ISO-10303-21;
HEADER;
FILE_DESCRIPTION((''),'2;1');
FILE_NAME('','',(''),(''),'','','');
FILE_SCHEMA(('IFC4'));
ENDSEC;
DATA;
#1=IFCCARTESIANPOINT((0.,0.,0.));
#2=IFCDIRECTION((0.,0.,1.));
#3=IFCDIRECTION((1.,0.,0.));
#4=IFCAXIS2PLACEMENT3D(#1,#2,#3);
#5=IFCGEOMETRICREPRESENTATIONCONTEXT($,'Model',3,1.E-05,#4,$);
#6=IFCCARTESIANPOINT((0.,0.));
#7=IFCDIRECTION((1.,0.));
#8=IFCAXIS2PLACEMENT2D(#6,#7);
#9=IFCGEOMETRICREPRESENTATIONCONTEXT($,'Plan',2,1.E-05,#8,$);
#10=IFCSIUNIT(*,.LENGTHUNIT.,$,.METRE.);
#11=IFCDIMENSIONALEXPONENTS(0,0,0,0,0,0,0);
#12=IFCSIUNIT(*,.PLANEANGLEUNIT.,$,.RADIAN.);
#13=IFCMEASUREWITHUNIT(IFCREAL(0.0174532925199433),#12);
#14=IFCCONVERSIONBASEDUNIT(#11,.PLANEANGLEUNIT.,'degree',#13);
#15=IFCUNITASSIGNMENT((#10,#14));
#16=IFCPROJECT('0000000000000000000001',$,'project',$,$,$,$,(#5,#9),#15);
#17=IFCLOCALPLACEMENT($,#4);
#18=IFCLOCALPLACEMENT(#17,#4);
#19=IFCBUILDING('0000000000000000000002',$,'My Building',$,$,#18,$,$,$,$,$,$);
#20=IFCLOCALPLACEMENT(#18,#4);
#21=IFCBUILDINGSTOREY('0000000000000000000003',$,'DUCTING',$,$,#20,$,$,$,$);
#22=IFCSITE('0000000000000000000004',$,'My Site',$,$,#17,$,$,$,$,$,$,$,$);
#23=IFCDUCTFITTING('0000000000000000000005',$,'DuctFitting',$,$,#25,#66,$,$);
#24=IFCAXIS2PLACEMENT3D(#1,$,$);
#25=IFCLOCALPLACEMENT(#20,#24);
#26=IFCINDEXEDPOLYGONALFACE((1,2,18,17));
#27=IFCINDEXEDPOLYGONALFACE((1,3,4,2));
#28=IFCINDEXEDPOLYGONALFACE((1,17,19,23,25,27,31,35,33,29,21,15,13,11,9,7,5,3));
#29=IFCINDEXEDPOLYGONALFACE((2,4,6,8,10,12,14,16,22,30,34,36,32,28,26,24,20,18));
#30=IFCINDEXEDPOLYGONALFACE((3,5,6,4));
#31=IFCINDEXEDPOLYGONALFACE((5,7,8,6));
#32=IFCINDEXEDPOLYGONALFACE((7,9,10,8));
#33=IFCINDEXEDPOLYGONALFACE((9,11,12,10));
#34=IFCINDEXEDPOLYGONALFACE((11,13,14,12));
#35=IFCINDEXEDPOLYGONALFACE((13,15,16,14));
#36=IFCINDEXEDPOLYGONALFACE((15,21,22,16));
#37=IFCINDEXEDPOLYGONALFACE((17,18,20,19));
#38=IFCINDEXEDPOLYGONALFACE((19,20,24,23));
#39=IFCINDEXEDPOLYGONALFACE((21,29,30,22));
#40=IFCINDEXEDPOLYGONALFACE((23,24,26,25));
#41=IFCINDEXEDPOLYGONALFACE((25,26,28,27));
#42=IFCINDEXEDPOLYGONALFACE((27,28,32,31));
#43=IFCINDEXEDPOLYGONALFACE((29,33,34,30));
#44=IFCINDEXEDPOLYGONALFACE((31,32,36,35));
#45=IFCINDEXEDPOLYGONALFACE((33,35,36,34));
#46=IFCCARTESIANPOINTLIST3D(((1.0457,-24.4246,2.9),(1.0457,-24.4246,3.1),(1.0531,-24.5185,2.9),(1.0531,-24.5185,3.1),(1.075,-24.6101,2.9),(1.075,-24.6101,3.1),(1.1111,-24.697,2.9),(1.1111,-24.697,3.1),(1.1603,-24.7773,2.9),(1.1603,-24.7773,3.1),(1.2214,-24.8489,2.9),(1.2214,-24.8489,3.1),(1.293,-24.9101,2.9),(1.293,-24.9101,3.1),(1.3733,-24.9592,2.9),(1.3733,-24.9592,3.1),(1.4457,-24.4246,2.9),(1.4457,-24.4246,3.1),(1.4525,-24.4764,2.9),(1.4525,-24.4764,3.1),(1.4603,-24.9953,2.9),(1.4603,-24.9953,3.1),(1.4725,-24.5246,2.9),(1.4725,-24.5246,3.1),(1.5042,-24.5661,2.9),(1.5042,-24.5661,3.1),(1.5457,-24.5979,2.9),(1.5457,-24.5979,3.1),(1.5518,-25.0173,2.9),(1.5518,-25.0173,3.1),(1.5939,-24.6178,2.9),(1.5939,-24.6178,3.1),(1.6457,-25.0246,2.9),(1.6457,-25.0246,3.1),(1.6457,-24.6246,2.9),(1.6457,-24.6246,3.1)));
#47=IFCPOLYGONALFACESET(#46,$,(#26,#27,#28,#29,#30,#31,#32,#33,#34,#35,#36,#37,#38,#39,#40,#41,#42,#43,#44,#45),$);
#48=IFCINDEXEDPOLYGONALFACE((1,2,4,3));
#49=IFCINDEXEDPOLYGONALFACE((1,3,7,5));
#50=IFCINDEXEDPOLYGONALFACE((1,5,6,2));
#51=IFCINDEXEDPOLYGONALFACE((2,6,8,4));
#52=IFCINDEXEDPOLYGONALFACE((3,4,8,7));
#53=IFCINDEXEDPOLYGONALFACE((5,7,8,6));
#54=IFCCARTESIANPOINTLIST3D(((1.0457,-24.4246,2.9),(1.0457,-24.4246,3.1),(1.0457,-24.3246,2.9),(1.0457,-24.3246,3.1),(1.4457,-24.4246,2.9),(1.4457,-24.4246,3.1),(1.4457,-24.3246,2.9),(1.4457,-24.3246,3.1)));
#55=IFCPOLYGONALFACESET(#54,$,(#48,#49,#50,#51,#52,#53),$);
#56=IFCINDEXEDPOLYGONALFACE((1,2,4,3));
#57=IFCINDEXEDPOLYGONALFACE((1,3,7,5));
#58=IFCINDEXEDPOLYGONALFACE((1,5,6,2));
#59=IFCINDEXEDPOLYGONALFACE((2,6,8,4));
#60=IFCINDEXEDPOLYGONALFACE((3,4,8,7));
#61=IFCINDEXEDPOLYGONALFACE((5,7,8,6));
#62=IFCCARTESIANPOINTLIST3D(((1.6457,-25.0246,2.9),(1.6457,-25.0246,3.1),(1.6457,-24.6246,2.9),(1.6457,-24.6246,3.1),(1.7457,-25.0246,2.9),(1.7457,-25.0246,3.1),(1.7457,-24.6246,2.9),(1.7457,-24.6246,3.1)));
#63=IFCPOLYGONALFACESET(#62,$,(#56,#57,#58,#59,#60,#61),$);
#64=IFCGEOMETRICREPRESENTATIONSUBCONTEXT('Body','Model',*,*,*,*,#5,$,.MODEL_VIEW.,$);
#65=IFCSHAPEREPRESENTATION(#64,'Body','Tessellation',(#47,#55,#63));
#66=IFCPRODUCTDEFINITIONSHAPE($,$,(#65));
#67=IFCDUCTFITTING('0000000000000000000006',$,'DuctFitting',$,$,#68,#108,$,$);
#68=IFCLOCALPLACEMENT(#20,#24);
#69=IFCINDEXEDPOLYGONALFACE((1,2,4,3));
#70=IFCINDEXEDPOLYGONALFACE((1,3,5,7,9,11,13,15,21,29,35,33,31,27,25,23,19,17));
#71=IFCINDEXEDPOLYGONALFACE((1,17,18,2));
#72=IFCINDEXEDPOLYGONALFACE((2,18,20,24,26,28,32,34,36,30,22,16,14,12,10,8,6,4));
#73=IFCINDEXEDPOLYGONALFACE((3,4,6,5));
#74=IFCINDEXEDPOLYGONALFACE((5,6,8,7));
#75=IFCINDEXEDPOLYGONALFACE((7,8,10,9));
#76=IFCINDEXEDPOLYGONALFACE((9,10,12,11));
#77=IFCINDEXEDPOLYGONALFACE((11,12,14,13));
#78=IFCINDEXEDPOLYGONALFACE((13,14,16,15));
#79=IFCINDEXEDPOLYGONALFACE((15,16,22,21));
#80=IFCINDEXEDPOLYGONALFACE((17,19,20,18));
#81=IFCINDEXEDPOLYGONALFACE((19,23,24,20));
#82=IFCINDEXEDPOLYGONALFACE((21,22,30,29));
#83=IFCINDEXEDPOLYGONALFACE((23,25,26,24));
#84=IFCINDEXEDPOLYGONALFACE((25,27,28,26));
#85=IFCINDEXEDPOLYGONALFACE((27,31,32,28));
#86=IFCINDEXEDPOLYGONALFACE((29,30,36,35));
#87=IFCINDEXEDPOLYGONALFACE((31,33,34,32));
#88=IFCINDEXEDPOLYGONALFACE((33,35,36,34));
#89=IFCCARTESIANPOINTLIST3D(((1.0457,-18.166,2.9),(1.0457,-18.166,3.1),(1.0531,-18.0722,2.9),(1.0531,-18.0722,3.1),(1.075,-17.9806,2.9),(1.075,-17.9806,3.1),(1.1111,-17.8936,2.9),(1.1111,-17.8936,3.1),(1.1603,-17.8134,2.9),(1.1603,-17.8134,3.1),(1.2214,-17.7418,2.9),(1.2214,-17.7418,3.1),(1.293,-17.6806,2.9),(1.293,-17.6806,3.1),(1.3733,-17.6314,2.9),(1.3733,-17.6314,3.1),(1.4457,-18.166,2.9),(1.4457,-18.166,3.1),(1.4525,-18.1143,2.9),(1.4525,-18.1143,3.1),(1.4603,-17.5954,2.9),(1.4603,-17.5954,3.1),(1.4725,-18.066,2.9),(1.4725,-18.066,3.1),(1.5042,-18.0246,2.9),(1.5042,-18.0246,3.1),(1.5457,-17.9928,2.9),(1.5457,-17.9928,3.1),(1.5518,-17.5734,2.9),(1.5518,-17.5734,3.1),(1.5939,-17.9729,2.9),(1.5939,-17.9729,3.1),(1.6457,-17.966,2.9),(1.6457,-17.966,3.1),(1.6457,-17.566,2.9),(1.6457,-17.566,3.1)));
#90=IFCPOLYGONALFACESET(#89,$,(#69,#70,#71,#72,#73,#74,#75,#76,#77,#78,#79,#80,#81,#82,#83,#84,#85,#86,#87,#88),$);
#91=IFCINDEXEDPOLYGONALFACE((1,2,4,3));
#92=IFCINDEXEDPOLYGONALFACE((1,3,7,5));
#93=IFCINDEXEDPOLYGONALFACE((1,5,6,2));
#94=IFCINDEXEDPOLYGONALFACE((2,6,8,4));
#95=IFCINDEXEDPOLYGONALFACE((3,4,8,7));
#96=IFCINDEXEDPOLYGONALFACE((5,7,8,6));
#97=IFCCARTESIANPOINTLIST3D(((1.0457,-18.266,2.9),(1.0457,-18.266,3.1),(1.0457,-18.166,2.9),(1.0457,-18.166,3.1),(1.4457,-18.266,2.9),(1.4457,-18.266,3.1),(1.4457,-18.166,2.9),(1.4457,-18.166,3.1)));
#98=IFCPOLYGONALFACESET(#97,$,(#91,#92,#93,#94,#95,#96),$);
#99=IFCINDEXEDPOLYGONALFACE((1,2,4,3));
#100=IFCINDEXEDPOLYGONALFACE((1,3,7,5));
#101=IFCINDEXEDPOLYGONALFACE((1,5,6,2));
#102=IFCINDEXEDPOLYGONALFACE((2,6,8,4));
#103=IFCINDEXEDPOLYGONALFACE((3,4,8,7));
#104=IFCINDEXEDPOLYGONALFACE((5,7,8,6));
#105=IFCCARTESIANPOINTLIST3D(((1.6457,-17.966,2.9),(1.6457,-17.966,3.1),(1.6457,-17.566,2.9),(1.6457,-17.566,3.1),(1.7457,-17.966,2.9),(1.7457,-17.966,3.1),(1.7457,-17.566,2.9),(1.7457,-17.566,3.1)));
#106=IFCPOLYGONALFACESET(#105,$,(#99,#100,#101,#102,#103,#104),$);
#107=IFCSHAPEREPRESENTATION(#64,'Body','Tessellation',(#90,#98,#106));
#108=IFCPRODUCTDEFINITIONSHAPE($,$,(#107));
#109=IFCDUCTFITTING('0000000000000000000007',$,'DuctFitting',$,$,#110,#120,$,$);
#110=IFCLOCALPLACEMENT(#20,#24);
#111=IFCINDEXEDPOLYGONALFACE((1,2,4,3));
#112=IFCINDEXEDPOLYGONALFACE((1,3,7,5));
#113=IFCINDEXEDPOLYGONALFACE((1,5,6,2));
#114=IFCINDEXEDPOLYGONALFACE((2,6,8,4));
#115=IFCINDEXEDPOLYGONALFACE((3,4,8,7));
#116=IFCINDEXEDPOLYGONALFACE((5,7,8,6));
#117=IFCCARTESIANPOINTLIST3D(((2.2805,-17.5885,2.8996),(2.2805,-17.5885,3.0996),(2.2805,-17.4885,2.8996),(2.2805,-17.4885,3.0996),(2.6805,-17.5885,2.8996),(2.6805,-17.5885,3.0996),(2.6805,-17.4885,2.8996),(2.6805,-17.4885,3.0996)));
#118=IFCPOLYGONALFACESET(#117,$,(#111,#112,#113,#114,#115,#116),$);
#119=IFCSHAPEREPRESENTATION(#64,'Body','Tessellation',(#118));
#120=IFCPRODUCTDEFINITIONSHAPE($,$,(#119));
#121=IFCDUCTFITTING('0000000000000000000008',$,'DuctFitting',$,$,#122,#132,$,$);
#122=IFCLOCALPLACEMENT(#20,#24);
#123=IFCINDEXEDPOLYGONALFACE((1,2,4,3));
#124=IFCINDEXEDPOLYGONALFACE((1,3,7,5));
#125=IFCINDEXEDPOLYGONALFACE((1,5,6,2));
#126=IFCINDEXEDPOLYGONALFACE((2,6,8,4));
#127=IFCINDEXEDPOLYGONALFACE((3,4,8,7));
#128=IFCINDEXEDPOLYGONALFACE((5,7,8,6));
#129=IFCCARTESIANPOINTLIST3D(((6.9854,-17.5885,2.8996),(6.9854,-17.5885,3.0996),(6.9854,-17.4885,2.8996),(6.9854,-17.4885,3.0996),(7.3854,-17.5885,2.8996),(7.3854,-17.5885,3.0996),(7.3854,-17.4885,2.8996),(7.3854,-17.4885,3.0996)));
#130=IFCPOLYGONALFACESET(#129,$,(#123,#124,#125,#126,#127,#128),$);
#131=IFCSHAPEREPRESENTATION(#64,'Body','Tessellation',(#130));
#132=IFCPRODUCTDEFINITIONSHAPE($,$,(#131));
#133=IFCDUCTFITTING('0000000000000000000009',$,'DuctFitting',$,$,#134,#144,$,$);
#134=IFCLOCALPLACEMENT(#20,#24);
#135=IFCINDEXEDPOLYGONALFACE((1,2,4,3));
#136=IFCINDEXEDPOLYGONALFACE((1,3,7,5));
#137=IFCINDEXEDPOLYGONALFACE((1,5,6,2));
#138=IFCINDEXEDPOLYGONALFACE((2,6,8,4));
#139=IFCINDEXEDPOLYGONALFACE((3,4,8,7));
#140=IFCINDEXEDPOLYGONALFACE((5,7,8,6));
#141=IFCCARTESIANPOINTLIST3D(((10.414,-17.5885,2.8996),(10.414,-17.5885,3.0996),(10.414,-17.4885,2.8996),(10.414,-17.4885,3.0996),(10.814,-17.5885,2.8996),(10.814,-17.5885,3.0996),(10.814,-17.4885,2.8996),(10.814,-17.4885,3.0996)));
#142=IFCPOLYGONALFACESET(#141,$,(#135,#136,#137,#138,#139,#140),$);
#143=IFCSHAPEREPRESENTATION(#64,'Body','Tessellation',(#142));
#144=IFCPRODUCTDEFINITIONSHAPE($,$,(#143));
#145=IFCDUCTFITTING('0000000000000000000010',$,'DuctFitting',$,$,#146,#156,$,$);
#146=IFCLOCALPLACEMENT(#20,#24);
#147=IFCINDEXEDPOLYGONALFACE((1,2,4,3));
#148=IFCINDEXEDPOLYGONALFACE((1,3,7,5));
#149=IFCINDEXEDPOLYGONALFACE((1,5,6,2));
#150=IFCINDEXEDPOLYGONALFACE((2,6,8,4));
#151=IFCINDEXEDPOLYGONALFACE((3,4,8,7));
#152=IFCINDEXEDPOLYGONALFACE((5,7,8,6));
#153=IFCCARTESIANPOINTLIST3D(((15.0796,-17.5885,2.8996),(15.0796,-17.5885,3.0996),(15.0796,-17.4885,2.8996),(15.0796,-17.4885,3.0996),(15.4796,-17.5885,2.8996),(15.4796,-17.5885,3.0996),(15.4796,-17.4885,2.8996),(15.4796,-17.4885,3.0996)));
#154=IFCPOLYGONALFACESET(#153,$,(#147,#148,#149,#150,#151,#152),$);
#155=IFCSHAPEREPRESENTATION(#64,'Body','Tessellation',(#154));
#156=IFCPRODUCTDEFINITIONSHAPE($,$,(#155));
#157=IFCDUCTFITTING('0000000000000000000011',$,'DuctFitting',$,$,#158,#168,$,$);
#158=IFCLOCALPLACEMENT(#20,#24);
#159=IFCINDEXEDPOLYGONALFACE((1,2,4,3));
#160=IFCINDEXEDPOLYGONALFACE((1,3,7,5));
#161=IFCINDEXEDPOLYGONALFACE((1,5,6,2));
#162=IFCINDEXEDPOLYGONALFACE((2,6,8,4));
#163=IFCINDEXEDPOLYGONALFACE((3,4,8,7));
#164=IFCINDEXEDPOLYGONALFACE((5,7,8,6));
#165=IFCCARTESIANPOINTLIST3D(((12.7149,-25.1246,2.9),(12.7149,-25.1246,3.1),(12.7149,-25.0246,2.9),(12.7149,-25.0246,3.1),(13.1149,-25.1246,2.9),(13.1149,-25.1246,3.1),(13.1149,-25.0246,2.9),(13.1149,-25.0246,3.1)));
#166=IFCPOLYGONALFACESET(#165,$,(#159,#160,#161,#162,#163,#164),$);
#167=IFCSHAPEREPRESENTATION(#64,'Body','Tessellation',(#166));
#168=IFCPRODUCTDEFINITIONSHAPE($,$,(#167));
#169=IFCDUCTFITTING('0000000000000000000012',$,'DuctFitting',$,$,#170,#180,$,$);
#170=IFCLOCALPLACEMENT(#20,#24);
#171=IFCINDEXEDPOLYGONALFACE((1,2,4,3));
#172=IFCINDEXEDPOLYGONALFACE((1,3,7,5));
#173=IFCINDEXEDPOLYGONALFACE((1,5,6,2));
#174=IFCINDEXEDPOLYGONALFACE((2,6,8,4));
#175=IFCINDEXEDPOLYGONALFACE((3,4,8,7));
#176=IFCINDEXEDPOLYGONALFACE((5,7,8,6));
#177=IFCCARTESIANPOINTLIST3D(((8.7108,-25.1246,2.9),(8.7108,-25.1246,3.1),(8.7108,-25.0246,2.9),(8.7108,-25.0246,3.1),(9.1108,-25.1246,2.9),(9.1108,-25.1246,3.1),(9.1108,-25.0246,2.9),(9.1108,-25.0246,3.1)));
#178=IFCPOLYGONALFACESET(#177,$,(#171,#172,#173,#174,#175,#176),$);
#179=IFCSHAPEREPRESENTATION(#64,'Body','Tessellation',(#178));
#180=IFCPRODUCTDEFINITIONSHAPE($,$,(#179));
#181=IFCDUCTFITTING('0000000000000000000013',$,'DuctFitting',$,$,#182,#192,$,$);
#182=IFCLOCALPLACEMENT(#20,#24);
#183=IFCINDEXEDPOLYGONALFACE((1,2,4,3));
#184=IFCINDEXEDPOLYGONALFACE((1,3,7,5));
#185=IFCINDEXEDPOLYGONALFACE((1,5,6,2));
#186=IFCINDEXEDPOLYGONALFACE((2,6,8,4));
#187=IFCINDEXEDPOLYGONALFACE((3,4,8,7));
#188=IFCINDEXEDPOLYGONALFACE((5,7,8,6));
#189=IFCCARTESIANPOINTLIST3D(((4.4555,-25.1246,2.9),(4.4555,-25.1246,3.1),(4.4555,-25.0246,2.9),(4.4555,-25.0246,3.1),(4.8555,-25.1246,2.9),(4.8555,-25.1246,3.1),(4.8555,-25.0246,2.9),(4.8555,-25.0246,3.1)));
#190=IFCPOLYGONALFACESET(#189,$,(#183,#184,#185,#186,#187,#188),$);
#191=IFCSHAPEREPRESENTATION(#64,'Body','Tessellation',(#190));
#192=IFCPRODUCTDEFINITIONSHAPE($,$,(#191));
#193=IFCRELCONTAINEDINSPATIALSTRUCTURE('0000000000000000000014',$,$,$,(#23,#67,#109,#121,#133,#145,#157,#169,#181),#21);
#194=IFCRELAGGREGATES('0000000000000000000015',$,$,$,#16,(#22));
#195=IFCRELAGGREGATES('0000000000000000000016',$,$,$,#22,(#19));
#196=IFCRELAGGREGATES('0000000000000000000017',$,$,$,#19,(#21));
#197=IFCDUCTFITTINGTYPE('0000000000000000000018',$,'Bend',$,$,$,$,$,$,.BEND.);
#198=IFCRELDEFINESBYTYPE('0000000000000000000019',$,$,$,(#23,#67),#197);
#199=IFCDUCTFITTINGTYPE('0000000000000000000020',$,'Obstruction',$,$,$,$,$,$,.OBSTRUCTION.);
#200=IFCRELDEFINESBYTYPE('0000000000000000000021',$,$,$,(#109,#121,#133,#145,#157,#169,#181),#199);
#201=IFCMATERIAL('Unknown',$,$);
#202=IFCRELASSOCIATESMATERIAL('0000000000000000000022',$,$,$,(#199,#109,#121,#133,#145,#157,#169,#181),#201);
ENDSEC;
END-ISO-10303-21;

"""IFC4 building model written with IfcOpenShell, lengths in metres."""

from ifc_helpers import new_model, entity, si_unit, converted_unit, frame, origin_with_axes, origin_2d_with_axis, place, context, subcontext, project, spatial, line, arc, indexed_curve, rectangle, outline, extrude, source, transform, mapped, material, material_profile, profile_set, profile_usage, type_object, type_shapes, element, save


model = new_model("IFC4")

# Units and contexts
model_context = context("Model", 3, precision=1e-05, world=origin_with_axes())
plan_context = context("Plan", 2, precision=1e-05, world=origin_2d_with_axis())
body_context = subcontext(model_context, "Body", "Model", "MODEL_VIEW")
ifc_project = project(units=[si_unit("LENGTHUNIT", "METRE"), converted_unit("PLANEANGLEUNIT", "degree", entity("IfcReal", 0.0174532925199433), si_unit("PLANEANGLEUNIT", "RADIAN"), dimensions=[0, 0, 0, 0, 0, 0, 0])], contexts=[model_context, plan_context])

# Site, building, storey
site_placement = place(None, origin_with_axes())
site = spatial("IfcSite", under=ifc_project, at=site_placement, Name="My Site")
building_placement = place(site_placement, origin_with_axes())
building = spatial("IfcBuilding", under=site, at=building_placement, Name="My Building")
storey_placement = place(building_placement, origin_with_axes())
storey = spatial("IfcBuildingStorey", under=building, at=storey_placement, Name="DUCTING")

# Shared definitions
ifc_material = material(Name="Unknown")

# Duct fittings
duct_fitting_type_1 = type_object("IfcDuctFittingType", Name="Bend", PredefinedType="BEND")
shared_shape = source(origin_with_axes(), body_context, "Body", "SweptSolid", [
    extrude(outline(indexed_curve([(0.2, 0.0), (0.2586, -0.1414), (0.4, -0.2), (0.4, -0.6), (-0.0243, -0.4243), (-0.2, 0.0)], segments=[arc(1, 2, 3), line(3, 4), arc(4, 5, 6), line(6, 1)])), frame((0.0, -0.1, -0.1), z_axis=(0.0, -1.0, 0.0), x_axis=(1.0, 0.0, 0.0)), (0.0, 0.0, -1.0), 0.2),
    extrude(rectangle(XDim=0.4, YDim=0.2), origin_with_axes(), (0.0, 0.0, -1.0), 0.1),
    extrude(rectangle(XDim=0.4, YDim=0.2), frame((0.4, 0.0, -0.5), z_axis=(1.0, 0.0, 0.0), x_axis=(0.0, 0.0, 1.0)), (0.0, 0.0, 1.0), 0.1),
])
type_shapes(duct_fitting_type_1, [shared_shape])
for number, where, z_axis, x_axis, name in (
    (1, (1.2457, -24.3246, 3.0), (0.0, 1.0, 0.0), (1.0, 0.0, 0.0), "DuctFitting"),
    (2, (1.2457, -18.266, 3.0), (0.0, -1.0, 0.0), (1.0, 0.0, 0.0), "DuctFitting"),
):
    element("IfcDuctFitting", number, at=place(storey_placement, frame(where, z_axis=z_axis, x_axis=x_axis)), inside=storey, type_object=duct_fitting_type_1, Name=name, context=body_context, shape_type="MappedRepresentation", body=[
        mapped(shared_shape, transform((0.0, 0.0, 0.0), x_axis=(1.0, 0.0, 0.0), y_axis=(0.0, 1.0, 0.0), z_axis=(0.0, 0.0, 1.0), scale=1.0)),
    ])
ifc_material_profile_1 = material_profile(ifc_material, rectangle(XDim=0.4, YDim=0.2))
ifc_profile_set_1 = profile_set([ifc_material_profile_1])
ifc_profile_usage_1 = profile_usage(ifc_profile_set_1, cardinal=5)
duct_fitting_type_2 = type_object("IfcDuctFittingType", Name="Obstruction", PredefinedType="OBSTRUCTION", material=ifc_profile_set_1)
duct_fitting_1_placement = place(storey_placement, frame((2.4805, -17.5885, 2.9996), z_axis=(0.0, 1.0, 0.0), x_axis=(-1.0, 0.0, 0.0)))
element("IfcDuctFitting", 3, at=duct_fitting_1_placement, inside=storey, type_object=duct_fitting_type_2, material=ifc_profile_usage_1, Name="DuctFitting", context=body_context, shape_type="SweptSolid", body=[
    extrude(rectangle(XDim=0.4, YDim=0.2), origin_with_axes(), (0.0, 0.0, 1.0), 0.1),
])
ifc_profile_usage_2 = profile_usage(ifc_profile_set_1, cardinal=5)
duct_fitting_2_placement = place(storey_placement, frame((7.1854, -17.5885, 2.9996), z_axis=(0.0, 1.0, 0.0), x_axis=(-1.0, 0.0, 0.0)))
element("IfcDuctFitting", 4, at=duct_fitting_2_placement, inside=storey, type_object=duct_fitting_type_2, material=ifc_profile_usage_2, Name="DuctFitting", context=body_context, shape_type="SweptSolid", body=[
    extrude(rectangle(XDim=0.4, YDim=0.2), origin_with_axes(), (0.0, 0.0, 1.0), 0.1),
])
ifc_profile_usage_3 = profile_usage(ifc_profile_set_1, cardinal=5)
duct_fitting_3_placement = place(storey_placement, frame((10.614, -17.5885, 2.9996), z_axis=(0.0, 1.0, 0.0), x_axis=(-1.0, 0.0, 0.0)))
element("IfcDuctFitting", 5, at=duct_fitting_3_placement, inside=storey, type_object=duct_fitting_type_2, material=ifc_profile_usage_3, Name="DuctFitting", context=body_context, shape_type="SweptSolid", body=[
    extrude(rectangle(XDim=0.4, YDim=0.2), origin_with_axes(), (0.0, 0.0, 1.0), 0.1),
])
ifc_profile_usage_4 = profile_usage(ifc_profile_set_1, cardinal=5)
duct_fitting_4_placement = place(storey_placement, frame((15.2796, -17.5885, 2.9996), z_axis=(0.0, 1.0, 0.0), x_axis=(-1.0, 0.0, 0.0)))
element("IfcDuctFitting", 6, at=duct_fitting_4_placement, inside=storey, type_object=duct_fitting_type_2, material=ifc_profile_usage_4, Name="DuctFitting", context=body_context, shape_type="SweptSolid", body=[
    extrude(rectangle(XDim=0.4, YDim=0.2), origin_with_axes(), (0.0, 0.0, 1.0), 0.1),
])
ifc_profile_usage_5 = profile_usage(ifc_profile_set_1, cardinal=5)
duct_fitting_5_placement = place(storey_placement, frame((12.9149, -25.0246, 3.0), z_axis=(0.0, -1.0, 0.0), x_axis=(1.0, 0.0, 0.0)))
element("IfcDuctFitting", 7, at=duct_fitting_5_placement, inside=storey, type_object=duct_fitting_type_2, material=ifc_profile_usage_5, Name="DuctFitting", context=body_context, shape_type="SweptSolid", body=[
    extrude(rectangle(XDim=0.4, YDim=0.2), origin_with_axes(), (0.0, 0.0, 1.0), 0.1),
])
ifc_profile_usage_6 = profile_usage(ifc_profile_set_1, cardinal=5)
duct_fitting_6_placement = place(storey_placement, frame((8.9108, -25.0246, 3.0), z_axis=(0.0, -1.0, 0.0), x_axis=(1.0, 0.0, 0.0)))
element("IfcDuctFitting", 8, at=duct_fitting_6_placement, inside=storey, type_object=duct_fitting_type_2, material=ifc_profile_usage_6, Name="DuctFitting", context=body_context, shape_type="SweptSolid", body=[
    extrude(rectangle(XDim=0.4, YDim=0.2), origin_with_axes(), (0.0, 0.0, 1.0), 0.1),
])
ifc_profile_usage_7 = profile_usage(ifc_profile_set_1, cardinal=5)
duct_fitting_7_placement = place(storey_placement, frame((4.6555, -25.0246, 3.0), z_axis=(0.0, -1.0, 0.0), x_axis=(1.0, 0.0, 0.0)))
element("IfcDuctFitting", 9, at=duct_fitting_7_placement, inside=storey, type_object=duct_fitting_type_2, material=ifc_profile_usage_7, Name="DuctFitting", context=body_context, shape_type="SweptSolid", body=[
    extrude(rectangle(XDim=0.4, YDim=0.2), origin_with_axes(), (0.0, 0.0, 1.0), 0.1),
])

save(model, "model.ifc")
